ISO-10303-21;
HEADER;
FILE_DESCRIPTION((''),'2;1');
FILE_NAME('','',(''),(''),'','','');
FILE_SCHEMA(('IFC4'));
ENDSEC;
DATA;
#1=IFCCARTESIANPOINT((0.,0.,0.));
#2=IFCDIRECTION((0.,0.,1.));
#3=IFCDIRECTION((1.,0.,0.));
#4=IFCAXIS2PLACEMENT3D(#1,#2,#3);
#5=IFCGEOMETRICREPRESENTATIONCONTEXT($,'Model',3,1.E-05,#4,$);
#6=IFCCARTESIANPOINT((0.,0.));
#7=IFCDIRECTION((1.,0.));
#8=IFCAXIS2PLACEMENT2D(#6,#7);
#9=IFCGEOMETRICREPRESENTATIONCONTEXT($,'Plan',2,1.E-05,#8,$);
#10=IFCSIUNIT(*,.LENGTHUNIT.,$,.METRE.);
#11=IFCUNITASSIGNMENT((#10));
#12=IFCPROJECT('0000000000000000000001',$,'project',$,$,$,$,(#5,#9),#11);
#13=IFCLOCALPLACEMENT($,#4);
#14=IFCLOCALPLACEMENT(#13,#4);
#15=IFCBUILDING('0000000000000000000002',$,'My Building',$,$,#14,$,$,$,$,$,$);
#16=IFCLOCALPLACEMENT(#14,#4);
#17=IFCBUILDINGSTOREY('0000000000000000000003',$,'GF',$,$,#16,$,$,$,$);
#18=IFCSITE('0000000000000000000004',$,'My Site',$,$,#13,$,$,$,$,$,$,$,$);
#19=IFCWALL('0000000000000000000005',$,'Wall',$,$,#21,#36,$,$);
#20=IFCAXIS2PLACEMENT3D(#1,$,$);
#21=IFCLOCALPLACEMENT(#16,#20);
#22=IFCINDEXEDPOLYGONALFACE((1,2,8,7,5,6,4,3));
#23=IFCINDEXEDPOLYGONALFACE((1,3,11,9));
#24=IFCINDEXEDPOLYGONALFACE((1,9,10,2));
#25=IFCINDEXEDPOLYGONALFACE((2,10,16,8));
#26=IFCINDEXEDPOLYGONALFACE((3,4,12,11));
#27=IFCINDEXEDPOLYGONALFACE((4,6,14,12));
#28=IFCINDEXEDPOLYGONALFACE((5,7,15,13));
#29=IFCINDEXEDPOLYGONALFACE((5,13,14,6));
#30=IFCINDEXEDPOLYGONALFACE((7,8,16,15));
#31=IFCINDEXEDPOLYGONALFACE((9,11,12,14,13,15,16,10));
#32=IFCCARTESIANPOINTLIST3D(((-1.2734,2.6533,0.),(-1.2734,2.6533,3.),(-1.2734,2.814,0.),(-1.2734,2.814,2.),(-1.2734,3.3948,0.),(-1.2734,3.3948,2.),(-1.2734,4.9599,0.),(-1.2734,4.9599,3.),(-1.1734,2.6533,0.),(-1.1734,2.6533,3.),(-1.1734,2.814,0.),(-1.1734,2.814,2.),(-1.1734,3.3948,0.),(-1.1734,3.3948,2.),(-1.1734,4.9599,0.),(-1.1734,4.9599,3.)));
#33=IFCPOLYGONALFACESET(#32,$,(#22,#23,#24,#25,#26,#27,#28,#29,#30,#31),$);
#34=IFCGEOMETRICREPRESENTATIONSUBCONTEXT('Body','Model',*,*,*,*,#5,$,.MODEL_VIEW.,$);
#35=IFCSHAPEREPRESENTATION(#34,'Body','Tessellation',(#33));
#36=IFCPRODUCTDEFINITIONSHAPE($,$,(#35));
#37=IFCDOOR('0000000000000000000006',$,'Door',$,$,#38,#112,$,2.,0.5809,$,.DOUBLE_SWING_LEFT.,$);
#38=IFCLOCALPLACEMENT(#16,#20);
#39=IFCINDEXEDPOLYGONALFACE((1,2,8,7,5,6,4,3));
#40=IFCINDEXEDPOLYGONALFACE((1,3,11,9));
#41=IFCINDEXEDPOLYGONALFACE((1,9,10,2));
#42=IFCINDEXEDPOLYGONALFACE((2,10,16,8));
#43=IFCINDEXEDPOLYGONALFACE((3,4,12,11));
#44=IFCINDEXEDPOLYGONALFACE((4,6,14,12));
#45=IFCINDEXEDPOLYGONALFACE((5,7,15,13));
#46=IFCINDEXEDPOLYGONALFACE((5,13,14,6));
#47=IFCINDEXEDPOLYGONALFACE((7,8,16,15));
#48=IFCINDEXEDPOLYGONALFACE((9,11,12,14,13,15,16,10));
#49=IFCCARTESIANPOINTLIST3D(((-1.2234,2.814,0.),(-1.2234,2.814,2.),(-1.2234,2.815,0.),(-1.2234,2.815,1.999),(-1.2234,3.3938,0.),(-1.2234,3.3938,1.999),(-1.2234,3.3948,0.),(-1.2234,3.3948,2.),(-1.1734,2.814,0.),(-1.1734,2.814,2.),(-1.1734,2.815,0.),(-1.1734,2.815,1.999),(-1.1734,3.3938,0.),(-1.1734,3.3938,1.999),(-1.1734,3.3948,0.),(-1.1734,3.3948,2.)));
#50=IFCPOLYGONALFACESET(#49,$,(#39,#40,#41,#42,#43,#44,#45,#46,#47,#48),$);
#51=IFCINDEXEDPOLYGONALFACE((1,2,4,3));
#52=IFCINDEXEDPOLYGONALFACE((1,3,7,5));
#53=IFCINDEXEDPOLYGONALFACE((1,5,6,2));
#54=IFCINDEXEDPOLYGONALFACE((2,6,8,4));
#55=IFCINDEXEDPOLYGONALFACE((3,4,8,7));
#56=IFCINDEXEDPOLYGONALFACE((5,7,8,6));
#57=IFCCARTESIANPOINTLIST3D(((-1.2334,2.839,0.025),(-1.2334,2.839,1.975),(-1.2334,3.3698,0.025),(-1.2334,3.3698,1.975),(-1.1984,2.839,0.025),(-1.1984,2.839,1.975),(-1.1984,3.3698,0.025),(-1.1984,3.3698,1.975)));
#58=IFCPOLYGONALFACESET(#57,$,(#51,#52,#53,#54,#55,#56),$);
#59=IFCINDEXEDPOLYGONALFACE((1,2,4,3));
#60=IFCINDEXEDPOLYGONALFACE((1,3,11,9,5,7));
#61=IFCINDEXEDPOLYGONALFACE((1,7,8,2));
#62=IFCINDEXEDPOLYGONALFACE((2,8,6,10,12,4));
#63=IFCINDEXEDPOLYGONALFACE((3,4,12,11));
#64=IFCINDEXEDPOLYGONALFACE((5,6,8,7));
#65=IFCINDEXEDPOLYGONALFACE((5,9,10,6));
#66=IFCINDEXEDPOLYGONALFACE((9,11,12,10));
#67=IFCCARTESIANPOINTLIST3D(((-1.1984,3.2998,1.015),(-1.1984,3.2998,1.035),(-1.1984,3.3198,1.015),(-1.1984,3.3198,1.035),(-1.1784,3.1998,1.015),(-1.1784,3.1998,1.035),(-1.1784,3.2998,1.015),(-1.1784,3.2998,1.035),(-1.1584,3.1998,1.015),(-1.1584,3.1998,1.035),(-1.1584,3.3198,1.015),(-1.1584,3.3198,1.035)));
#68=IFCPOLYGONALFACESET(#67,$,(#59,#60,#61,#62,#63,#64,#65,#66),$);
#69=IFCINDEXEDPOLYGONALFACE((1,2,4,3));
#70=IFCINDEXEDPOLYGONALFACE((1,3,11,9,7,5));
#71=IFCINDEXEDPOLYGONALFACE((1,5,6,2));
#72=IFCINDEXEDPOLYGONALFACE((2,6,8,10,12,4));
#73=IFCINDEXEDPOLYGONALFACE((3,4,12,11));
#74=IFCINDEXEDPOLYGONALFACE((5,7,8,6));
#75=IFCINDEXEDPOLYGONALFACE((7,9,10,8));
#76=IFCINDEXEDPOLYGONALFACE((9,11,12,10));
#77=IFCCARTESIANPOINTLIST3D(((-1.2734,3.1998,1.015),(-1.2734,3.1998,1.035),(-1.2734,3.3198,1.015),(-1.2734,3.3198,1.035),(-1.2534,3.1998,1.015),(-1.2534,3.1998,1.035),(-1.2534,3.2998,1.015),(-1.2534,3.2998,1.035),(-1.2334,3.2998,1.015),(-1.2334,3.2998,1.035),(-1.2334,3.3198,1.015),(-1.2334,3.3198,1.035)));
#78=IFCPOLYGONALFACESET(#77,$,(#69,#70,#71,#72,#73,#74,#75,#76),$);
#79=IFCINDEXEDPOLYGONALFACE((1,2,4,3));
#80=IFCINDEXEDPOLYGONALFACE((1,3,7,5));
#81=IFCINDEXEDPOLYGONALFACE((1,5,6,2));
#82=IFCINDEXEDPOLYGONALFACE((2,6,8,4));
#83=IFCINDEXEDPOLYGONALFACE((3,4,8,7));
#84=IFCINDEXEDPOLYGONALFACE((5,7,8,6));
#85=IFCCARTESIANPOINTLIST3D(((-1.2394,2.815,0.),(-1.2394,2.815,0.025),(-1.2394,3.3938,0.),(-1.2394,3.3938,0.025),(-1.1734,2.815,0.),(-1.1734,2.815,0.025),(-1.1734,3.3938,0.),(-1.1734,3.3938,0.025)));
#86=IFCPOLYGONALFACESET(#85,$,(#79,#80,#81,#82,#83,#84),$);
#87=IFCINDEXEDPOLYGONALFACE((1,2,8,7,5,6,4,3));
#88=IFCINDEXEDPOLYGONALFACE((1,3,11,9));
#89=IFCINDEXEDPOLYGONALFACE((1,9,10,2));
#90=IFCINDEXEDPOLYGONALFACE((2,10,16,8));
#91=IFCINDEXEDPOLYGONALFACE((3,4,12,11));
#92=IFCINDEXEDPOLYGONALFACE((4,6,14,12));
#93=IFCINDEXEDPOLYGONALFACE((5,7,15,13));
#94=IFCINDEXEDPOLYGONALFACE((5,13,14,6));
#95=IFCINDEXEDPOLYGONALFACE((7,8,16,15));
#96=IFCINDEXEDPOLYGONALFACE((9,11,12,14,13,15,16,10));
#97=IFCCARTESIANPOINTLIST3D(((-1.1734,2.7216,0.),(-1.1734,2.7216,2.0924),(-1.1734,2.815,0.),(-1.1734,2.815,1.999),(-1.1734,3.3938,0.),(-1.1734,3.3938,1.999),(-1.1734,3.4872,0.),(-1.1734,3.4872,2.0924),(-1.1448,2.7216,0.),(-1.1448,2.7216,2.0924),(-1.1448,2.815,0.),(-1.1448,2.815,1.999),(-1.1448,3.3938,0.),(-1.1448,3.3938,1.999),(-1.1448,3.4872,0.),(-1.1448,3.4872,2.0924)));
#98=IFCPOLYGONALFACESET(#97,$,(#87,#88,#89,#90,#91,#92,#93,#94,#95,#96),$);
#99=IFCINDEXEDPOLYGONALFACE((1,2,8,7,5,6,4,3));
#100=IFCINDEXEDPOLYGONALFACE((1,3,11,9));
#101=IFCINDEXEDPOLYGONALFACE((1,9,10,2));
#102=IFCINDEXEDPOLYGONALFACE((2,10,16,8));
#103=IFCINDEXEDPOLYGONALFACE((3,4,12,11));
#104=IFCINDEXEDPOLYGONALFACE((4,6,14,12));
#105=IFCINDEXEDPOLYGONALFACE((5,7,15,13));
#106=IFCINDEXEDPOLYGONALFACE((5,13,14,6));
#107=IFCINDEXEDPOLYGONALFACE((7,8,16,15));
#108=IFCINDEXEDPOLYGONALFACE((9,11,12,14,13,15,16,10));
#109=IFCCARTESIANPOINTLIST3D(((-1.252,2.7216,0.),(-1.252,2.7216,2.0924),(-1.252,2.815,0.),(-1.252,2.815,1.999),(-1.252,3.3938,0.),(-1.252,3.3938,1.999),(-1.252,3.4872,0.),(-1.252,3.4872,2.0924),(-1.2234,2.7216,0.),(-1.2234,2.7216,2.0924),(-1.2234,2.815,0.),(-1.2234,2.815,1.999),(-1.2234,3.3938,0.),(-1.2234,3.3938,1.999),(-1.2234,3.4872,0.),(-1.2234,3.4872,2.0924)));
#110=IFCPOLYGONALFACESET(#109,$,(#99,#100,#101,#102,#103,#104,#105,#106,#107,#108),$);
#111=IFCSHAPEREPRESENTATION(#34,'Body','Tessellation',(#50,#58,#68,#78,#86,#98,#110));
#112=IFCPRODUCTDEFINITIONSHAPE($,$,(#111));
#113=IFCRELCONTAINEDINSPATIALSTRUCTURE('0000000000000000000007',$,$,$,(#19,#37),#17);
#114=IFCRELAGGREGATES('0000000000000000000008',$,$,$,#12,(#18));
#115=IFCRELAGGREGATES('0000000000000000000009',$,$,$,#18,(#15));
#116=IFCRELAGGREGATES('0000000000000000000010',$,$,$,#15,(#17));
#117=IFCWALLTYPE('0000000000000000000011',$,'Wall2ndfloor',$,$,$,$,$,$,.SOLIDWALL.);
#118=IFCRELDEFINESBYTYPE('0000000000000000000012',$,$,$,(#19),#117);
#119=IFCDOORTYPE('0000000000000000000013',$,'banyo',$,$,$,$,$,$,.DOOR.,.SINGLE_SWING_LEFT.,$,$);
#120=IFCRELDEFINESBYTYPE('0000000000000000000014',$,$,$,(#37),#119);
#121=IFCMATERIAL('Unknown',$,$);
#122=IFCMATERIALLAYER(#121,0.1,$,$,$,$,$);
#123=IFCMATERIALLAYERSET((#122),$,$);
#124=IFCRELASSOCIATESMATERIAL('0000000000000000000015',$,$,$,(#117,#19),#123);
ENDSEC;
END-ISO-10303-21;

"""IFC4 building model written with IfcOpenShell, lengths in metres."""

from ifc_helpers import new_model, entity, si_unit, frame, origin_with_axes, origin_2d_with_axis, place, context, subcontext, project, spatial, line, indexed_curve, outline, extrude, shape, source, transform, mapped, material, layer, layer_set, layer_usage, type_object, type_shapes, element, fill, save


model = new_model("IFC4")

# Units and contexts
model_context = context("Model", 3, precision=1e-05, world=origin_with_axes())
plan_context = context("Plan", 2, precision=1e-05, world=origin_2d_with_axis())
body_context_1 = subcontext(model_context, "Body", "Model", "MODEL_VIEW")
body_context_2 = subcontext(plan_context, "Body", "Plan", "PLAN_VIEW")
ifc_project = project(units=[si_unit("LENGTHUNIT", "METRE")], contexts=[model_context, plan_context])

# Site, building, storey
site_placement = place(None, origin_with_axes())
site = spatial("IfcSite", under=ifc_project, at=site_placement, Name="My Site")
building_placement = place(site_placement, origin_with_axes())
building = spatial("IfcBuilding", under=site, at=building_placement, Name="My Building")
storey_placement = place(building_placement, origin_with_axes())
storey = spatial("IfcBuildingStorey", under=building, at=storey_placement, Name="GF")

# Shared definitions
ifc_material = material(Name="Unknown")

# Shared definitions
ifc_layer_1 = layer(ifc_material, 0.1)
ifc_layer_set_1 = layer_set([ifc_layer_1])
wall_type = type_object("IfcWallType", Name="Wall2ndfloor", PredefinedType="SOLIDWALL", material=ifc_layer_set_1)

# Wall, opening, door
ifc_layer_usage_1 = layer_usage(ifc_layer_set_1, "AXIS2", "POSITIVE", 0.0)
wall_1_placement = place(storey_placement, frame((-1.1734, 2.6533, 0.0), z_axis=(0.0, 0.0, 1.0), x_axis=(0.0, 1.0, 0.0)))
wall_1 = element("IfcWall", 1, at=wall_1_placement, inside=storey, type_object=wall_type, material=ifc_layer_usage_1, Name="Wall", context=body_context_1, shape_type="SweptSolid", body=[
    extrude(outline(indexed_curve([(0.0, 0.0), (0.0, 0.1), (2.3066, 0.1), (2.3066, 0.0)], segments=[line(1, 2, 3, 4, 1)])), origin_with_axes(), (0.0, 0.0, 1.0), 3.0),
])
shared_shape_1 = source(origin_with_axes(), body_context_1, "Body", "SweptSolid", [
    extrude(outline(indexed_curve([(0.0, 0.0), (0.5809, 0.0), (0.5809, 2.0), (0.0, 2.0)], segments=[line(1, 2, 3, 4, 1)])), frame((0.0, -0.6, 0.0), z_axis=(0.0, -1.0, 0.0), x_axis=(1.0, 0.0, 0.0)), (0.0, 0.0, -1.0), 1.2),
])
opening_1_placement = place(wall_1_placement, frame((0.1607, 0.0, 0.0), z_axis=(0.0, 0.0, 1.0), x_axis=(1.0, 0.0, 0.0)))
opening_1 = element("IfcOpeningElement", 2, at=opening_1_placement, cuts=wall_1, PredefinedType="OPENING", context=body_context_1, shape_type="MappedRepresentation", body=[
    mapped(shared_shape_1, transform((0.0, 0.0, 0.0), x_axis=(1.0, 0.0, 0.0), y_axis=(0.0, 1.0, 0.0), z_axis=(0.0, 0.0, 1.0), scale=1.0)),
])
door_type_1 = type_object("IfcDoorType", Name="banyo", OperationType="SINGLE_SWING_LEFT", PredefinedType="DOOR")
shared_shape_2 = source(origin_with_axes(), body_context_1, "Body", "SweptSolid", [
    extrude(outline(indexed_curve([(0.0, 0.0), (0.0, 2.0), (0.5809, 2.0), (0.5809, 0.0), (0.5799, 0.0), (0.5799, 1.999), (0.001, 1.999), (0.001, 0.0)], segments=[line(1, 2, 3, 4, 5, 6, 7, 8, 1)])), frame((0.0, 0.0, 0.0), z_axis=(0.0, -1.0, 0.0), x_axis=(1.0, 0.0, 0.0)), (0.0, 0.0, -1.0), 0.05),
    extrude(outline(indexed_curve([(0.0, 0.0), (0.5309, 0.0), (0.5309, 0.035), (0.0, 0.035)], segments=[line(1, 2, 3, 4, 1)])), frame((0.025, 0.025, 0.025), z_axis=(0.0, 0.0, 1.0), x_axis=(1.0, 0.0, 0.0)), (0.0, 0.0, 1.0), 1.95),
    extrude(outline(indexed_curve([(0.0, 0.0), (0.0, -0.04), (-0.12, -0.04), (-0.12, -0.02), (-0.02, -0.02), (-0.02, 0.0)], segments=[line(1, 2, 3, 4, 5, 6, 1)])), frame((0.5059, 0.025, 1.015), z_axis=(0.0, 0.0, 1.0), x_axis=(1.0, 0.0, 0.0)), (0.0, 0.0, 1.0), 0.02),
    extrude(outline(indexed_curve([(0.0, 0.0), (0.0, 0.04), (-0.12, 0.04), (-0.12, 0.02), (-0.02, 0.02), (-0.02, 0.0)], segments=[line(1, 2, 3, 4, 5, 6, 1)])), frame((0.5059, 0.06, 1.015), z_axis=(0.0, 0.0, 1.0), x_axis=(1.0, 0.0, 0.0)), (0.0, 0.0, 1.0), 0.02),
    extrude(outline(indexed_curve([(0.0, 0.0), (0.5789, 0.0), (0.5789, 0.066), (0.0, 0.066)], segments=[line(1, 2, 3, 4, 1)])), frame((0.001, 0.0, 0.0), z_axis=(0.0, 0.0, 1.0), x_axis=(1.0, 0.0, 0.0)), (0.0, 0.0, 1.0), 0.025),
    extrude(outline(indexed_curve([(0.0, 0.0), (0.0, 2.0924), (0.7656, 2.0924), (0.7656, 0.0), (0.6723, 0.0), (0.6723, 1.999), (0.0934, 1.999), (0.0934, 0.0)], segments=[line(1, 2, 3, 4, 5, 6, 7, 8, 1)])), frame((-0.0924, -0.0286, 0.0), z_axis=(0.0, -1.0, 0.0), x_axis=(1.0, 0.0, 0.0)), (0.0, 0.0, -1.0), 0.0286),
    extrude(outline(indexed_curve([(0.0, 0.0), (0.0, 2.0924), (0.7656, 2.0924), (0.7656, 0.0), (0.6723, 0.0), (0.6723, 1.999), (0.0934, 1.999), (0.0934, 0.0)], segments=[line(1, 2, 3, 4, 5, 6, 7, 8, 1)])), frame((-0.0924, 0.05, 0.0), z_axis=(0.0, -1.0, 0.0), x_axis=(1.0, 0.0, 0.0)), (0.0, 0.0, -1.0), 0.0286),
])
shared_shape_3 = source(origin_with_axes(), body_context_2, "Body", "Curve2D", [
    entity("IfcIndexedPolyCurve", entity("IfcCartesianPointList2D", [[0.0, 0.0], [0.001, 0.0], [0.001, 0.05], [0.0, 0.05]]), [entity("IfcLineIndex", [1, 2, 3, 4, 1])]),
    entity("IfcIndexedPolyCurve", entity("IfcCartesianPointList2D", [[0.5809, 0.0], [0.5799, 0.0], [0.5799, 0.05], [0.5809, 0.05]]), [entity("IfcLineIndex", [1, 2, 3, 4, 1])]),
    entity("IfcIndexedPolyCurve", entity("IfcCartesianPointList2D", [[0.025, 0.05], [0.025, -0.4809], [0.06, -0.4809]])),
    entity("IfcTrimmedCurve", entity("IfcEllipse", entity("IfcAxis2Placement2D", entity("IfcCartesianPoint", [0.06, 0.05]), entity("IfcDirection", [1.0, 0.0])), 0.4959, 0.5309), [entity("IfcCartesianPoint", [0.06, -0.4809])], [entity("IfcCartesianPoint", [0.06, 0.5809])], True, "CARTESIAN"),
    entity("IfcIndexedPolyCurve", entity("IfcCartesianPointList2D", [[0.025, 0.05], [0.06, 0.05], [0.06, 0.5809], [0.025, 0.5809]]), [entity("IfcLineIndex", [1, 2, 3, 4, 1])]),
])
type_shapes(door_type_1, [shared_shape_2, shared_shape_3])
door_1_placement = place(opening_1_placement, frame((0.0, 0.0, 0.0), z_axis=(0.0, 0.0, 1.0), x_axis=(1.0, 0.0, 0.0)))
door_1 = element("IfcDoor", 3, at=door_1_placement, inside=storey, type_object=door_type_1, Name="Door", OperationType="DOUBLE_SWING_LEFT", OverallHeight=2.0, OverallWidth=0.5809, shapes=[
    shape(body_context_1, "Body", "MappedRepresentation", [mapped(shared_shape_2, transform((0.0, 0.0, 0.0), x_axis=(1.0, 0.0, 0.0), y_axis=(0.0, 1.0, 0.0), z_axis=(0.0, 0.0, 1.0), scale=1.0))]),
    shape(body_context_2, "Body", "MappedRepresentation", [mapped(shared_shape_3, transform((0.0, 0.0, 0.0), x_axis=(1.0, 0.0, 0.0), y_axis=(0.0, 1.0, 0.0), z_axis=(0.0, 0.0, 1.0), scale=1.0))]),
])
fill(opening_1, door_1)

save(model, "model.ifc")
